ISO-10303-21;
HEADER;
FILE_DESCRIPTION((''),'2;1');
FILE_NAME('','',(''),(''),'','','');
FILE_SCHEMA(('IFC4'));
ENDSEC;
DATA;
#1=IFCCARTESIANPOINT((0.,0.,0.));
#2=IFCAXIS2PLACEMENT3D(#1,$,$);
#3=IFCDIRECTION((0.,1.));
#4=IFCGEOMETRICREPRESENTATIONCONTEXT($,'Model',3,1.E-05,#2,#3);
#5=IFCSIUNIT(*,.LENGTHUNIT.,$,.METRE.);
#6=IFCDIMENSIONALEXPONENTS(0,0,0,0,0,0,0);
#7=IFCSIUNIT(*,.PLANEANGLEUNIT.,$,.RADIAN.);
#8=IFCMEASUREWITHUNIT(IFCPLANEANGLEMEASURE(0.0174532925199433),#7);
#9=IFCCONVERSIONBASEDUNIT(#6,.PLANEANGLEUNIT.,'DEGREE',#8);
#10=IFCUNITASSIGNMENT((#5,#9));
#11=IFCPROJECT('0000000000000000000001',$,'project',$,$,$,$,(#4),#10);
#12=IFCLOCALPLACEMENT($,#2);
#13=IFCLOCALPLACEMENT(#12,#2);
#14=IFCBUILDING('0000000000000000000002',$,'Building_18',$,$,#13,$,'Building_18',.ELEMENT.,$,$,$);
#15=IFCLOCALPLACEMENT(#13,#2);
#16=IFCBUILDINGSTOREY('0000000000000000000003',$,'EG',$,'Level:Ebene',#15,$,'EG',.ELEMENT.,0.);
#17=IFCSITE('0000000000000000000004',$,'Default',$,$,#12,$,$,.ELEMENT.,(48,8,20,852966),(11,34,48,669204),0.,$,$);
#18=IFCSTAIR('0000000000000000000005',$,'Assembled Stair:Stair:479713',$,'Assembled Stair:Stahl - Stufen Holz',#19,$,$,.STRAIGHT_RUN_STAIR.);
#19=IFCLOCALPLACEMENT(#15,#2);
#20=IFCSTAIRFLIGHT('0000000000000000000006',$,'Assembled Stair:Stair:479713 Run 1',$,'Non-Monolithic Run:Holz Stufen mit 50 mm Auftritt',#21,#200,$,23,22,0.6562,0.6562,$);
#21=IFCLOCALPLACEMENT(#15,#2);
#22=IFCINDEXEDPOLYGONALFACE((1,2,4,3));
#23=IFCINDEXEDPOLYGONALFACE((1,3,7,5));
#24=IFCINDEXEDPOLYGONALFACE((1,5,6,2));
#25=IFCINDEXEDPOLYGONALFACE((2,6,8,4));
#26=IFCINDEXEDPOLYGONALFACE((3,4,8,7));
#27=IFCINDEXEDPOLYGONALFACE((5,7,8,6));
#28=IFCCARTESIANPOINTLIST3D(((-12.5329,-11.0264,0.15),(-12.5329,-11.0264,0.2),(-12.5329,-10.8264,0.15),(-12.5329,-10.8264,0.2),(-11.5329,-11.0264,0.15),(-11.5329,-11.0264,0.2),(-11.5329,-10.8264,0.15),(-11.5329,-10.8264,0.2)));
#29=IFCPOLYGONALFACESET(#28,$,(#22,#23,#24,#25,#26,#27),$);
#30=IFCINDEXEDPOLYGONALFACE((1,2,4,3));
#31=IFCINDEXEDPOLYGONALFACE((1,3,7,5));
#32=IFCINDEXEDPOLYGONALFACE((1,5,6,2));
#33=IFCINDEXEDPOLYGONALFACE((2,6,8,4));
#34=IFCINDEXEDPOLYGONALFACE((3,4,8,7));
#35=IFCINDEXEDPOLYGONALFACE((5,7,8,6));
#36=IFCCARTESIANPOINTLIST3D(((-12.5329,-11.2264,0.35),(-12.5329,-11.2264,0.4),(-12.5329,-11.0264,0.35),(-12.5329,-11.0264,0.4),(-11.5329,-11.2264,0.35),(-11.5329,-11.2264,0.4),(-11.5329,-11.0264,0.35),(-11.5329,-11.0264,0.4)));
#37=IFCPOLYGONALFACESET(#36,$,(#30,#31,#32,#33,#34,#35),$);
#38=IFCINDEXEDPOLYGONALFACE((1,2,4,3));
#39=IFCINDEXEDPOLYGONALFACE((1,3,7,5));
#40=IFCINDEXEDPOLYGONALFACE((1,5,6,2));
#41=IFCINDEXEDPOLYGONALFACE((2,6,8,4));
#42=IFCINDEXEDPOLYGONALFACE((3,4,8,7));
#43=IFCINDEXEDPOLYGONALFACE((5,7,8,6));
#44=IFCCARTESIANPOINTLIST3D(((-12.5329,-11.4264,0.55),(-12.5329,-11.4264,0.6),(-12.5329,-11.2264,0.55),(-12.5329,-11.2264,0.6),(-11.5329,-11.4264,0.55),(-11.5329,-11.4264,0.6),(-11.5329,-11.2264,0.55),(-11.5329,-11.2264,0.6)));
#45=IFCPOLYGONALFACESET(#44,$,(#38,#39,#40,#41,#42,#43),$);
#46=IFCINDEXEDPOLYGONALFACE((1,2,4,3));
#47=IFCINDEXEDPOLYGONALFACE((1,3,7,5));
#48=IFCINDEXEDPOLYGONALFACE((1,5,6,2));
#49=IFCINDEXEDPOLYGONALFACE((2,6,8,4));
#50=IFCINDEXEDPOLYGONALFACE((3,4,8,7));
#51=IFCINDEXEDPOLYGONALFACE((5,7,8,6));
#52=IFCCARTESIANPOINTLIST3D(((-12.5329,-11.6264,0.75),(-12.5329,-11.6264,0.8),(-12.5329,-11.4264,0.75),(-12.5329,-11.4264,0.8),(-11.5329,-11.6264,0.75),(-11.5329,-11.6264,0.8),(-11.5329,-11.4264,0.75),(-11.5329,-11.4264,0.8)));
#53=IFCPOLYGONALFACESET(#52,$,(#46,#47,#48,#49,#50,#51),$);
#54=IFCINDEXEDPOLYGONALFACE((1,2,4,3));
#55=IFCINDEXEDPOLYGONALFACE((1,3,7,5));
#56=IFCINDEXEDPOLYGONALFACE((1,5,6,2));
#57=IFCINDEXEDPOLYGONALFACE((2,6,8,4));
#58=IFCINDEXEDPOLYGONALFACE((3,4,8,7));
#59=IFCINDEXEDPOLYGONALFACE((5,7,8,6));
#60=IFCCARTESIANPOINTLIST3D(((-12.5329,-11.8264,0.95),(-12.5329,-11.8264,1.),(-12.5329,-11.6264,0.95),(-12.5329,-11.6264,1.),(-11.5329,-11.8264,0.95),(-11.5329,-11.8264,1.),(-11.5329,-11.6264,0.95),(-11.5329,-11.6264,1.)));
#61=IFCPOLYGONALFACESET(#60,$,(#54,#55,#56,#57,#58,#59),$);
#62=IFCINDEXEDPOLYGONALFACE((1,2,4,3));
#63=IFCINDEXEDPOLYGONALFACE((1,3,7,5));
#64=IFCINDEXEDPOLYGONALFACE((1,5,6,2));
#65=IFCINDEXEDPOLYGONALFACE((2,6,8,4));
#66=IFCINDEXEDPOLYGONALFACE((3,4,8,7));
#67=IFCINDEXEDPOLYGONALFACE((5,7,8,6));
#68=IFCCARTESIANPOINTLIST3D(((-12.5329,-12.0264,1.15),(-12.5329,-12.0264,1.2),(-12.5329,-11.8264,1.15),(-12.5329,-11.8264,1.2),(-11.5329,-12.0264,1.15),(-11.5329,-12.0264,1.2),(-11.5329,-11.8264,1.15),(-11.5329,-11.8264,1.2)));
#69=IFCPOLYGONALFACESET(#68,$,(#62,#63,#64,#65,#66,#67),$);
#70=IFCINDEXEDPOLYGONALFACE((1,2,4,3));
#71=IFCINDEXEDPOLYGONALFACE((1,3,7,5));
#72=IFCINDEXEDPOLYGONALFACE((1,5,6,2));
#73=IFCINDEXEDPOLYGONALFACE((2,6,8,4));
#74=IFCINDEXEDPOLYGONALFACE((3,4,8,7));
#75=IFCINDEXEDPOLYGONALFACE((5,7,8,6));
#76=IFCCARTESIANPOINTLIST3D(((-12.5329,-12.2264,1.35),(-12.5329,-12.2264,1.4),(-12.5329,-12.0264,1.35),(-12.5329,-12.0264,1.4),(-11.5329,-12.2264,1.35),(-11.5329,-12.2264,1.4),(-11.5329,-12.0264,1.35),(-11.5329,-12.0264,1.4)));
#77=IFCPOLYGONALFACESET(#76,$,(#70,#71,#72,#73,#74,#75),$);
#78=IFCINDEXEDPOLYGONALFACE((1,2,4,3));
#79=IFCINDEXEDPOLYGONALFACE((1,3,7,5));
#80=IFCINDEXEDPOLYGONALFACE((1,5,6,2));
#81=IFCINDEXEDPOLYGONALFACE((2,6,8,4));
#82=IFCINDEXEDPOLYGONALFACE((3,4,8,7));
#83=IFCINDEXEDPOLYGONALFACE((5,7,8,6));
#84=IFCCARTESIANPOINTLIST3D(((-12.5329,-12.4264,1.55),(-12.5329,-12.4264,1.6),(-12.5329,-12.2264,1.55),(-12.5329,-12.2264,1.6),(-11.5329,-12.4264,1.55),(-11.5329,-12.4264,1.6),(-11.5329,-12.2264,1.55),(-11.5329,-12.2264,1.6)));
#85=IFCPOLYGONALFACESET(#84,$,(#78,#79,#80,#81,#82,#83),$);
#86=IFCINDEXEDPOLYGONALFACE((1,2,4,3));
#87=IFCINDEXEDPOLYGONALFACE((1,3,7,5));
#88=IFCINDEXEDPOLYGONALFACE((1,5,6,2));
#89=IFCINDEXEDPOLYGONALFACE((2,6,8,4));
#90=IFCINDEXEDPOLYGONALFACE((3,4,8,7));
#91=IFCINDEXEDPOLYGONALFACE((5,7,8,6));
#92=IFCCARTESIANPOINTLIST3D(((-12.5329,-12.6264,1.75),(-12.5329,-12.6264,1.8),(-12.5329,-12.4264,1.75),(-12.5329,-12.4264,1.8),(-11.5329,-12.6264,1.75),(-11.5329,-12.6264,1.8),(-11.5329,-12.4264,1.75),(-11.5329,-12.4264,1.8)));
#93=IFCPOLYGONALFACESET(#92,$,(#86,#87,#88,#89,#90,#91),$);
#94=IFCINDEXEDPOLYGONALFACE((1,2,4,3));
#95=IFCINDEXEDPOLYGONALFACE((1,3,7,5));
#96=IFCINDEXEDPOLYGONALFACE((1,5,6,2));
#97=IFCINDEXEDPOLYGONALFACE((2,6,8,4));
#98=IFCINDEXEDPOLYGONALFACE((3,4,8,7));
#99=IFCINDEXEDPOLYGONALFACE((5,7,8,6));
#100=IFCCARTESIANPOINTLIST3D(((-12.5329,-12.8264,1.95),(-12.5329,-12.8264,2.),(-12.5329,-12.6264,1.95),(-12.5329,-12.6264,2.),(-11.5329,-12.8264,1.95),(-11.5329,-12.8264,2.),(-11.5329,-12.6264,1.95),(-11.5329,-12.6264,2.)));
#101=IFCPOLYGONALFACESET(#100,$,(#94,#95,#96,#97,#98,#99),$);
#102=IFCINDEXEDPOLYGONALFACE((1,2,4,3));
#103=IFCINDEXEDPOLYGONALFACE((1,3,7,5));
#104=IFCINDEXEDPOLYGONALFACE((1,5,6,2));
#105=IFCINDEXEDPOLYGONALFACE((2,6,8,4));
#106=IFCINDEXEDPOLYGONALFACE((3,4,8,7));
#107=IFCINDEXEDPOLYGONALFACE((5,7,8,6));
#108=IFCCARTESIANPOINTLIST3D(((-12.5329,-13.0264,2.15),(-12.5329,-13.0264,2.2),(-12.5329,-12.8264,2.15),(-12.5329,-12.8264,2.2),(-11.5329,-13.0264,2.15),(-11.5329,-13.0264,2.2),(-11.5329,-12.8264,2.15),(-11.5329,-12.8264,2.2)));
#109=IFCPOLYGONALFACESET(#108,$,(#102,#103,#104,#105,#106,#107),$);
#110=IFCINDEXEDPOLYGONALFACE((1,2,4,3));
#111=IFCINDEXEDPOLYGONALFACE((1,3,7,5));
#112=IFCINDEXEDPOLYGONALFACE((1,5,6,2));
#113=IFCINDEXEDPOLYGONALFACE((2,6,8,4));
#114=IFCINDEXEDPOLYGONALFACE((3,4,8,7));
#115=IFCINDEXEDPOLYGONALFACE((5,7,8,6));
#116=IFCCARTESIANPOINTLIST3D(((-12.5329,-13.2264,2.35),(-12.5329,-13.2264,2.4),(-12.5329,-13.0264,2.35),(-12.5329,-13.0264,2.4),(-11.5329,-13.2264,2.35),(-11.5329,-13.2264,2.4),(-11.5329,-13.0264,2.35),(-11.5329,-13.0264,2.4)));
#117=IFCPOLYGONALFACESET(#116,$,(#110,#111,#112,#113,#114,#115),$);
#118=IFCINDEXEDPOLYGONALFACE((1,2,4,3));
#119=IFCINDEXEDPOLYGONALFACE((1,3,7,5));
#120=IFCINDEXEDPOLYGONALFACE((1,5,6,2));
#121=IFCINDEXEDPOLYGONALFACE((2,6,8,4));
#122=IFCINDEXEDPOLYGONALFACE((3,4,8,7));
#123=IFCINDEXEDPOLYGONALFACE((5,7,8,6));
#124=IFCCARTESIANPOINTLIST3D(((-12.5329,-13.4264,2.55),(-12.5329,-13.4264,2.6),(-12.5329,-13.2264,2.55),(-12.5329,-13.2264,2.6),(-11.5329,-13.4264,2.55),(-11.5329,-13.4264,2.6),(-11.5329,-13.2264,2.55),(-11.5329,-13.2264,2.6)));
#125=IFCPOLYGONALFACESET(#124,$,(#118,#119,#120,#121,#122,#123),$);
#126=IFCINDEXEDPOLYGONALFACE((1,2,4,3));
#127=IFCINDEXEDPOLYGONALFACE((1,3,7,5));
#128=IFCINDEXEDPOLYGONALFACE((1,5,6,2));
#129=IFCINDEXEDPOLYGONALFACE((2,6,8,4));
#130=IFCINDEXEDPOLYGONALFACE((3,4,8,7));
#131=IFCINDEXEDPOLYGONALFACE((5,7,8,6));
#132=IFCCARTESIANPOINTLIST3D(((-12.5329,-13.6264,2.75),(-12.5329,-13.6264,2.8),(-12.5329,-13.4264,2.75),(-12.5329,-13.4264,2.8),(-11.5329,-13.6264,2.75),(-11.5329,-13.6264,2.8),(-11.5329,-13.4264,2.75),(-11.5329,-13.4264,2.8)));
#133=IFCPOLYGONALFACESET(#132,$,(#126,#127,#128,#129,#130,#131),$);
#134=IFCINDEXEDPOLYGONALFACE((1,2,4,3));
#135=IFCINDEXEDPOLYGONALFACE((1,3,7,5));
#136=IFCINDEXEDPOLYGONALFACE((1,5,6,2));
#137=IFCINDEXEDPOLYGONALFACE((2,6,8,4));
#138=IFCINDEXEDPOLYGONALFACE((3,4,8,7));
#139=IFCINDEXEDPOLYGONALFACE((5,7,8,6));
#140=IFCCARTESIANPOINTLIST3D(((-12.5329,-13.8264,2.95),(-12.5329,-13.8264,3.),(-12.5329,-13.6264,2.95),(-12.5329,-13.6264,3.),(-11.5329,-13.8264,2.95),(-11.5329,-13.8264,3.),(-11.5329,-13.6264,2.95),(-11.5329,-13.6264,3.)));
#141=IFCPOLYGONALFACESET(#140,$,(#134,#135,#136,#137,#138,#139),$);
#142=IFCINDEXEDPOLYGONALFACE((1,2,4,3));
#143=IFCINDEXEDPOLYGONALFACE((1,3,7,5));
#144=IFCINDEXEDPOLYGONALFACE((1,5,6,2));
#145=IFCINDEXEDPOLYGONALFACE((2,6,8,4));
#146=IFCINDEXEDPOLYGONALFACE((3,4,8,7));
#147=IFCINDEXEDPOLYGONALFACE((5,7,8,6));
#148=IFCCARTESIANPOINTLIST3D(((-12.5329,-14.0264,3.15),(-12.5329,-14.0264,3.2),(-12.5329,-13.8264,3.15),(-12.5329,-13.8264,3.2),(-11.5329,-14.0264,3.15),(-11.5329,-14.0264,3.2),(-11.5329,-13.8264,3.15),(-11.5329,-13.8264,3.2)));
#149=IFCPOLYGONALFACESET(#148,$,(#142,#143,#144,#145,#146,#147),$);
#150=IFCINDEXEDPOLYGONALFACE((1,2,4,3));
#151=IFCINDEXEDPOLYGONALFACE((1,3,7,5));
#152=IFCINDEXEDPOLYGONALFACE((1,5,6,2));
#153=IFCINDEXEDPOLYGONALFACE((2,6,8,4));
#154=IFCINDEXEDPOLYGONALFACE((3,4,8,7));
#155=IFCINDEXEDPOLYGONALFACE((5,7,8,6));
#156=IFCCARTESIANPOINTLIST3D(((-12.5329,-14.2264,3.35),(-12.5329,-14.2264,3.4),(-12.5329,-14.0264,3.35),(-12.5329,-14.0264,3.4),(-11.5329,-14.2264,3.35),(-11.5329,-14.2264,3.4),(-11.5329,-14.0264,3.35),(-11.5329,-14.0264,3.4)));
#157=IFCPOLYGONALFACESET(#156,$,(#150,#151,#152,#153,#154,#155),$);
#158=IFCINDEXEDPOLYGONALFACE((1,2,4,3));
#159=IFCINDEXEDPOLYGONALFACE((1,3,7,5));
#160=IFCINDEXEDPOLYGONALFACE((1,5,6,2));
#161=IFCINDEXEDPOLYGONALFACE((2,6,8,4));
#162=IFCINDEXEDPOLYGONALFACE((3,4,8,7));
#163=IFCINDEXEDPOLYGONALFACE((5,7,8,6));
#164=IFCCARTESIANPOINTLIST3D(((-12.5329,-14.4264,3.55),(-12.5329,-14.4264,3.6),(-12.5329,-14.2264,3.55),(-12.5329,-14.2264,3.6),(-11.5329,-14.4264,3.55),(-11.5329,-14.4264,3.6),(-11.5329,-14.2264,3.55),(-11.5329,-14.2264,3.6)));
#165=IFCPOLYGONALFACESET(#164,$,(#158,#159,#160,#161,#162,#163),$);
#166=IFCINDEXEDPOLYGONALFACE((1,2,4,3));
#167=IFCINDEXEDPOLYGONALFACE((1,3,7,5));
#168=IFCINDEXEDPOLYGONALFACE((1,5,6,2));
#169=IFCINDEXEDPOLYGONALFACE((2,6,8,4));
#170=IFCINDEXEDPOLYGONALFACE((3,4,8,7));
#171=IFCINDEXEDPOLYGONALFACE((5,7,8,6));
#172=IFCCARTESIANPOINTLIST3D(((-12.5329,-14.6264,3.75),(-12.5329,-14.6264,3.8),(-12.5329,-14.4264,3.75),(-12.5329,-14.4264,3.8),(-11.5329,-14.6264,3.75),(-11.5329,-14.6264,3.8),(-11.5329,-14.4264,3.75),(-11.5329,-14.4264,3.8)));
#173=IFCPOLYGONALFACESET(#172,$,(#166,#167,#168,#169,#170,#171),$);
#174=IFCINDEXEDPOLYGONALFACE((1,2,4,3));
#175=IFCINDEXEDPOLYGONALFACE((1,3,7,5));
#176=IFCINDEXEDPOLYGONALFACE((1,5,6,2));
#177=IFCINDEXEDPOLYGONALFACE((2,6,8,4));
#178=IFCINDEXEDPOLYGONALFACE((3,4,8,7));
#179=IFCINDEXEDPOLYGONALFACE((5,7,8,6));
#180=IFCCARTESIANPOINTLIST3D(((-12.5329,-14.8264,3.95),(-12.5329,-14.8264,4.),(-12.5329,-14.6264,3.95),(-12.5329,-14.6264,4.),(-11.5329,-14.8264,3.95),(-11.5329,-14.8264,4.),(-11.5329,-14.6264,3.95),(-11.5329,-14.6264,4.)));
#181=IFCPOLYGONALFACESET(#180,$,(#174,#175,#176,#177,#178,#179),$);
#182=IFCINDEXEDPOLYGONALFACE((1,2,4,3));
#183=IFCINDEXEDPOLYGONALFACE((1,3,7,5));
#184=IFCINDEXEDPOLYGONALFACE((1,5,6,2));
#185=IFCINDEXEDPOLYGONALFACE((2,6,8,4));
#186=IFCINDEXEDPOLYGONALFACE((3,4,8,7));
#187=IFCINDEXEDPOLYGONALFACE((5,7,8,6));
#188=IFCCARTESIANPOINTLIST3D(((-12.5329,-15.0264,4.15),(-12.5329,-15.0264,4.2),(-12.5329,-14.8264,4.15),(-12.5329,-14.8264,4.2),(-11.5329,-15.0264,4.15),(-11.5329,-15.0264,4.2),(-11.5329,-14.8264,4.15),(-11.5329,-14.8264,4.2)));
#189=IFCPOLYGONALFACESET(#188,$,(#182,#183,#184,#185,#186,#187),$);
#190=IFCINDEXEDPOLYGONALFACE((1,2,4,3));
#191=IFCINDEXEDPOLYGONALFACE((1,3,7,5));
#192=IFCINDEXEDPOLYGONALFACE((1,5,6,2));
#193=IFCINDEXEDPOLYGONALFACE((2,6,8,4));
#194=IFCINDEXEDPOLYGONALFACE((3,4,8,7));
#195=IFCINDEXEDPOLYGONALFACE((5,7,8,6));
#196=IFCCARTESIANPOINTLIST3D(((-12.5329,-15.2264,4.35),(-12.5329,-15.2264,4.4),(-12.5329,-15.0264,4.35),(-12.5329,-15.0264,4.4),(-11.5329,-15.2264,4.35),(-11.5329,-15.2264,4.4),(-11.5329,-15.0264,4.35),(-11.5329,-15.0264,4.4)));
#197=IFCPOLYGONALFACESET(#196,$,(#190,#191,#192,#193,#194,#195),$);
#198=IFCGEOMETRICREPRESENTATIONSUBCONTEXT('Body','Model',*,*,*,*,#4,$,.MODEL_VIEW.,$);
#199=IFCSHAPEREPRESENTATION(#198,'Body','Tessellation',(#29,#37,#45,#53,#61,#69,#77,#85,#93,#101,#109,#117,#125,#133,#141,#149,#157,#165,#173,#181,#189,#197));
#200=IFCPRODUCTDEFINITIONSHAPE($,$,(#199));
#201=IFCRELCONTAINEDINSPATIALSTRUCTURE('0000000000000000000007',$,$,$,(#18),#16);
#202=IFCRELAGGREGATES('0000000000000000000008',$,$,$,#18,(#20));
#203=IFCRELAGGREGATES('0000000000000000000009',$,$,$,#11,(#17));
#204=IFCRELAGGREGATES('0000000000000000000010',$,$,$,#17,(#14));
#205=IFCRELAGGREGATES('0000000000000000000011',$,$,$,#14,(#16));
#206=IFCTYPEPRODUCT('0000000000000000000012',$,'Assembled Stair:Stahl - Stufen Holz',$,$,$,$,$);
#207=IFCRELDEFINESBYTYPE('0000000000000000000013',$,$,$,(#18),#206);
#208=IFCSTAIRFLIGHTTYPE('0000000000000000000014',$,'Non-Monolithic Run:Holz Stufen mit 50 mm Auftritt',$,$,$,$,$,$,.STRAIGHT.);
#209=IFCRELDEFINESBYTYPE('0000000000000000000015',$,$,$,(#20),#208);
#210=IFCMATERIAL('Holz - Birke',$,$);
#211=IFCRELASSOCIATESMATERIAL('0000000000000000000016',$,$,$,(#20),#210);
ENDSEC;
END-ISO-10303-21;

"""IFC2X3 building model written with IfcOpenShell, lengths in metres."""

from ifc_helpers import new_model, entity, si_unit, converted_unit, direction, frame, frame_2d, origin, place, context, subcontext, project, spatial, rectangle, extrude, material, type_object, element, aggregate, save


model = new_model("IFC2X3")

# Units and contexts
model_context = context("Model", 3, precision=1e-05, world=origin(), true_north=direction((0.0, 1.0)))
body_context = subcontext(model_context, "Body", "Model", "MODEL_VIEW")
ifc_project = project(units=[si_unit("LENGTHUNIT", "METRE"), converted_unit("PLANEANGLEUNIT", "DEGREE", entity("IfcPlaneAngleMeasure", 0.0174532925199433), si_unit("PLANEANGLEUNIT", "RADIAN"), dimensions=[0, 0, 0, 0, 0, 0, 0])], contexts=[model_context])

# Site, building, storey
site_placement = place(None, origin())
site = spatial("IfcSite", under=ifc_project, at=site_placement, Name="Default", CompositionType="ELEMENT", RefLatitude=(48, 8, 20, 852966), RefLongitude=(11, 34, 48, 669204), RefElevation=0.0)
building_placement = place(site_placement, origin())
building = spatial("IfcBuilding", under=site, at=building_placement, Name="Building_18", LongName="Building_18", CompositionType="ELEMENT")
storey_placement = place(building_placement, origin())
storey = spatial("IfcBuildingStorey", under=building, at=storey_placement, Name="EG", ObjectType="Level:Ebene", LongName="EG", CompositionType="ELEMENT", Elevation=0.0)

# Stair, stair flight
type_product = type_object("IfcTypeProduct", Name="Assembled Stair:Stahl - Stufen Holz")
stair_placement = place(storey_placement, origin())
stair = element("IfcStair", 1, at=stair_placement, inside=storey, type_object=type_product, Name="Assembled Stair:Stair:479713", ObjectType="Assembled Stair:Stahl - Stufen Holz", ShapeType="STRAIGHT_RUN_STAIR")
ifc_material_1 = material(Name="Holz - Birke")
stair_flight_type = type_object("IfcStairFlightType", Name="Non-Monolithic Run:Holz Stufen mit 50 mm Auftritt", PredefinedType="STRAIGHT")
stair_flight_placement = place(stair_placement, origin())
stair_flight = element("IfcStairFlight", 2, at=stair_flight_placement, type_object=stair_flight_type, material=ifc_material_1, Name="Assembled Stair:Stair:479713 Run 1", ObjectType="Non-Monolithic Run:Holz Stufen mit 50 mm Auftritt", NumberOfRiser=23, NumberOfTreads=22, RiserHeight=0.6562, TreadLength=0.6562, context=body_context, shape_type="SweptSolid", body=[
    extrude(rectangle(XDim=0.2, YDim=1.0, at=frame_2d((0.0, 0.0), x_axis=(1.0, 0.0))), frame((-12.0329, -10.9264, 0.15), z_axis=(0.0, 0.0, 1.0), x_axis=(0.0, 1.0, 0.0)), (0.0, 0.0, 1.0), 0.05),
    extrude(rectangle(XDim=0.2, YDim=1.0, at=frame_2d((0.0, 0.0), x_axis=(1.0, 0.0))), frame((-12.0329, -11.1264, 0.35), z_axis=(0.0, 0.0, 1.0), x_axis=(0.0, 1.0, 0.0)), (0.0, 0.0, 1.0), 0.05),
    extrude(rectangle(XDim=0.2, YDim=1.0, at=frame_2d((0.0, 0.0), x_axis=(1.0, 0.0))), frame((-12.0329, -11.3264, 0.55), z_axis=(0.0, 0.0, 1.0), x_axis=(0.0, 1.0, 0.0)), (0.0, 0.0, 1.0), 0.05),
    extrude(rectangle(XDim=0.2, YDim=1.0, at=frame_2d((0.0, 0.0), x_axis=(1.0, 0.0))), frame((-12.0329, -11.5264, 0.75), z_axis=(0.0, 0.0, 1.0), x_axis=(0.0, 1.0, 0.0)), (0.0, 0.0, 1.0), 0.05),
    extrude(rectangle(XDim=0.2, YDim=1.0, at=frame_2d((0.0, 0.0), x_axis=(1.0, 0.0))), frame((-12.0329, -11.7264, 0.95), z_axis=(0.0, 0.0, 1.0), x_axis=(0.0, 1.0, 0.0)), (0.0, 0.0, 1.0), 0.05),
    extrude(rectangle(XDim=0.2, YDim=1.0, at=frame_2d((0.0, 0.0), x_axis=(1.0, 0.0))), frame((-12.0329, -11.9264, 1.15), z_axis=(0.0, 0.0, 1.0), x_axis=(0.0, 1.0, 0.0)), (0.0, 0.0, 1.0), 0.05),
    extrude(rectangle(XDim=0.2, YDim=1.0, at=frame_2d((0.0, 0.0), x_axis=(1.0, 0.0))), frame((-12.0329, -12.1264, 1.35), z_axis=(0.0, 0.0, 1.0), x_axis=(0.0, 1.0, 0.0)), (0.0, 0.0, 1.0), 0.05),
    extrude(rectangle(XDim=0.2, YDim=1.0, at=frame_2d((0.0, 0.0), x_axis=(1.0, 0.0))), frame((-12.0329, -12.3264, 1.55), z_axis=(0.0, 0.0, 1.0), x_axis=(0.0, 1.0, 0.0)), (0.0, 0.0, 1.0), 0.05),
    extrude(rectangle(XDim=0.2, YDim=1.0, at=frame_2d((0.0, 0.0), x_axis=(1.0, 0.0))), frame((-12.0329, -12.5264, 1.75), z_axis=(0.0, 0.0, 1.0), x_axis=(0.0, 1.0, 0.0)), (0.0, 0.0, 1.0), 0.05),
    extrude(rectangle(XDim=0.2, YDim=1.0, at=frame_2d((0.0, 0.0), x_axis=(1.0, 0.0))), frame((-12.0329, -12.7264, 1.95), z_axis=(0.0, 0.0, 1.0), x_axis=(0.0, 1.0, 0.0)), (0.0, 0.0, 1.0), 0.05),
    extrude(rectangle(XDim=0.2, YDim=1.0, at=frame_2d((0.0, 0.0), x_axis=(1.0, 0.0))), frame((-12.0329, -12.9264, 2.15), z_axis=(0.0, 0.0, 1.0), x_axis=(0.0, 1.0, 0.0)), (0.0, 0.0, 1.0), 0.05),
    extrude(rectangle(XDim=0.2, YDim=1.0, at=frame_2d((0.0, 0.0), x_axis=(1.0, 0.0))), frame((-12.0329, -13.1264, 2.35), z_axis=(0.0, 0.0, 1.0), x_axis=(0.0, 1.0, 0.0)), (0.0, 0.0, 1.0), 0.05),
    extrude(rectangle(XDim=0.2, YDim=1.0, at=frame_2d((0.0, 0.0), x_axis=(1.0, 0.0))), frame((-12.0329, -13.3264, 2.55), z_axis=(0.0, 0.0, 1.0), x_axis=(0.0, 1.0, 0.0)), (0.0, 0.0, 1.0), 0.05),
    extrude(rectangle(XDim=0.2, YDim=1.0, at=frame_2d((0.0, 0.0), x_axis=(1.0, 0.0))), frame((-12.0329, -13.5264, 2.75), z_axis=(0.0, 0.0, 1.0), x_axis=(0.0, 1.0, 0.0)), (0.0, 0.0, 1.0), 0.05),
    extrude(rectangle(XDim=0.2, YDim=1.0, at=frame_2d((0.0, 0.0), x_axis=(1.0, 0.0))), frame((-12.0329, -13.7264, 2.95), z_axis=(0.0, 0.0, 1.0), x_axis=(0.0, 1.0, 0.0)), (0.0, 0.0, 1.0), 0.05),
    extrude(rectangle(XDim=0.2, YDim=1.0, at=frame_2d((0.0, 0.0), x_axis=(1.0, 0.0))), frame((-12.0329, -13.9264, 3.15), z_axis=(0.0, 0.0, 1.0), x_axis=(0.0, 1.0, 0.0)), (0.0, 0.0, 1.0), 0.05),
    extrude(rectangle(XDim=0.2, YDim=1.0, at=frame_2d((0.0, 0.0), x_axis=(1.0, 0.0))), frame((-12.0329, -14.1264, 3.35), z_axis=(0.0, 0.0, 1.0), x_axis=(0.0, 1.0, 0.0)), (0.0, 0.0, 1.0), 0.05),
    extrude(rectangle(XDim=0.2, YDim=1.0, at=frame_2d((0.0, 0.0), x_axis=(1.0, 0.0))), frame((-12.0329, -14.3264, 3.55), z_axis=(0.0, 0.0, 1.0), x_axis=(0.0, 1.0, 0.0)), (0.0, 0.0, 1.0), 0.05),
    extrude(rectangle(XDim=0.2, YDim=1.0, at=frame_2d((0.0, 0.0), x_axis=(1.0, 0.0))), frame((-12.0329, -14.5264, 3.75), z_axis=(0.0, 0.0, 1.0), x_axis=(0.0, 1.0, 0.0)), (0.0, 0.0, 1.0), 0.05),
    extrude(rectangle(XDim=0.2, YDim=1.0, at=frame_2d((0.0, 0.0), x_axis=(1.0, 0.0))), frame((-12.0329, -14.7264, 3.95), z_axis=(0.0, 0.0, 1.0), x_axis=(0.0, 1.0, 0.0)), (0.0, 0.0, 1.0), 0.05),
    extrude(rectangle(XDim=0.2, YDim=1.0, at=frame_2d((0.0, 0.0), x_axis=(1.0, 0.0))), frame((-12.0329, -14.9264, 4.15), z_axis=(0.0, 0.0, 1.0), x_axis=(0.0, 1.0, 0.0)), (0.0, 0.0, 1.0), 0.05),
    extrude(rectangle(XDim=0.2, YDim=1.0, at=frame_2d((0.0, 0.0), x_axis=(1.0, 0.0))), frame((-12.0329, -15.1264, 4.35), z_axis=(0.0, 0.0, 1.0), x_axis=(0.0, 1.0, 0.0)), (0.0, 0.0, 1.0), 0.05),
])
aggregate(stair, [stair_flight])

save(model, "model.ifc")
